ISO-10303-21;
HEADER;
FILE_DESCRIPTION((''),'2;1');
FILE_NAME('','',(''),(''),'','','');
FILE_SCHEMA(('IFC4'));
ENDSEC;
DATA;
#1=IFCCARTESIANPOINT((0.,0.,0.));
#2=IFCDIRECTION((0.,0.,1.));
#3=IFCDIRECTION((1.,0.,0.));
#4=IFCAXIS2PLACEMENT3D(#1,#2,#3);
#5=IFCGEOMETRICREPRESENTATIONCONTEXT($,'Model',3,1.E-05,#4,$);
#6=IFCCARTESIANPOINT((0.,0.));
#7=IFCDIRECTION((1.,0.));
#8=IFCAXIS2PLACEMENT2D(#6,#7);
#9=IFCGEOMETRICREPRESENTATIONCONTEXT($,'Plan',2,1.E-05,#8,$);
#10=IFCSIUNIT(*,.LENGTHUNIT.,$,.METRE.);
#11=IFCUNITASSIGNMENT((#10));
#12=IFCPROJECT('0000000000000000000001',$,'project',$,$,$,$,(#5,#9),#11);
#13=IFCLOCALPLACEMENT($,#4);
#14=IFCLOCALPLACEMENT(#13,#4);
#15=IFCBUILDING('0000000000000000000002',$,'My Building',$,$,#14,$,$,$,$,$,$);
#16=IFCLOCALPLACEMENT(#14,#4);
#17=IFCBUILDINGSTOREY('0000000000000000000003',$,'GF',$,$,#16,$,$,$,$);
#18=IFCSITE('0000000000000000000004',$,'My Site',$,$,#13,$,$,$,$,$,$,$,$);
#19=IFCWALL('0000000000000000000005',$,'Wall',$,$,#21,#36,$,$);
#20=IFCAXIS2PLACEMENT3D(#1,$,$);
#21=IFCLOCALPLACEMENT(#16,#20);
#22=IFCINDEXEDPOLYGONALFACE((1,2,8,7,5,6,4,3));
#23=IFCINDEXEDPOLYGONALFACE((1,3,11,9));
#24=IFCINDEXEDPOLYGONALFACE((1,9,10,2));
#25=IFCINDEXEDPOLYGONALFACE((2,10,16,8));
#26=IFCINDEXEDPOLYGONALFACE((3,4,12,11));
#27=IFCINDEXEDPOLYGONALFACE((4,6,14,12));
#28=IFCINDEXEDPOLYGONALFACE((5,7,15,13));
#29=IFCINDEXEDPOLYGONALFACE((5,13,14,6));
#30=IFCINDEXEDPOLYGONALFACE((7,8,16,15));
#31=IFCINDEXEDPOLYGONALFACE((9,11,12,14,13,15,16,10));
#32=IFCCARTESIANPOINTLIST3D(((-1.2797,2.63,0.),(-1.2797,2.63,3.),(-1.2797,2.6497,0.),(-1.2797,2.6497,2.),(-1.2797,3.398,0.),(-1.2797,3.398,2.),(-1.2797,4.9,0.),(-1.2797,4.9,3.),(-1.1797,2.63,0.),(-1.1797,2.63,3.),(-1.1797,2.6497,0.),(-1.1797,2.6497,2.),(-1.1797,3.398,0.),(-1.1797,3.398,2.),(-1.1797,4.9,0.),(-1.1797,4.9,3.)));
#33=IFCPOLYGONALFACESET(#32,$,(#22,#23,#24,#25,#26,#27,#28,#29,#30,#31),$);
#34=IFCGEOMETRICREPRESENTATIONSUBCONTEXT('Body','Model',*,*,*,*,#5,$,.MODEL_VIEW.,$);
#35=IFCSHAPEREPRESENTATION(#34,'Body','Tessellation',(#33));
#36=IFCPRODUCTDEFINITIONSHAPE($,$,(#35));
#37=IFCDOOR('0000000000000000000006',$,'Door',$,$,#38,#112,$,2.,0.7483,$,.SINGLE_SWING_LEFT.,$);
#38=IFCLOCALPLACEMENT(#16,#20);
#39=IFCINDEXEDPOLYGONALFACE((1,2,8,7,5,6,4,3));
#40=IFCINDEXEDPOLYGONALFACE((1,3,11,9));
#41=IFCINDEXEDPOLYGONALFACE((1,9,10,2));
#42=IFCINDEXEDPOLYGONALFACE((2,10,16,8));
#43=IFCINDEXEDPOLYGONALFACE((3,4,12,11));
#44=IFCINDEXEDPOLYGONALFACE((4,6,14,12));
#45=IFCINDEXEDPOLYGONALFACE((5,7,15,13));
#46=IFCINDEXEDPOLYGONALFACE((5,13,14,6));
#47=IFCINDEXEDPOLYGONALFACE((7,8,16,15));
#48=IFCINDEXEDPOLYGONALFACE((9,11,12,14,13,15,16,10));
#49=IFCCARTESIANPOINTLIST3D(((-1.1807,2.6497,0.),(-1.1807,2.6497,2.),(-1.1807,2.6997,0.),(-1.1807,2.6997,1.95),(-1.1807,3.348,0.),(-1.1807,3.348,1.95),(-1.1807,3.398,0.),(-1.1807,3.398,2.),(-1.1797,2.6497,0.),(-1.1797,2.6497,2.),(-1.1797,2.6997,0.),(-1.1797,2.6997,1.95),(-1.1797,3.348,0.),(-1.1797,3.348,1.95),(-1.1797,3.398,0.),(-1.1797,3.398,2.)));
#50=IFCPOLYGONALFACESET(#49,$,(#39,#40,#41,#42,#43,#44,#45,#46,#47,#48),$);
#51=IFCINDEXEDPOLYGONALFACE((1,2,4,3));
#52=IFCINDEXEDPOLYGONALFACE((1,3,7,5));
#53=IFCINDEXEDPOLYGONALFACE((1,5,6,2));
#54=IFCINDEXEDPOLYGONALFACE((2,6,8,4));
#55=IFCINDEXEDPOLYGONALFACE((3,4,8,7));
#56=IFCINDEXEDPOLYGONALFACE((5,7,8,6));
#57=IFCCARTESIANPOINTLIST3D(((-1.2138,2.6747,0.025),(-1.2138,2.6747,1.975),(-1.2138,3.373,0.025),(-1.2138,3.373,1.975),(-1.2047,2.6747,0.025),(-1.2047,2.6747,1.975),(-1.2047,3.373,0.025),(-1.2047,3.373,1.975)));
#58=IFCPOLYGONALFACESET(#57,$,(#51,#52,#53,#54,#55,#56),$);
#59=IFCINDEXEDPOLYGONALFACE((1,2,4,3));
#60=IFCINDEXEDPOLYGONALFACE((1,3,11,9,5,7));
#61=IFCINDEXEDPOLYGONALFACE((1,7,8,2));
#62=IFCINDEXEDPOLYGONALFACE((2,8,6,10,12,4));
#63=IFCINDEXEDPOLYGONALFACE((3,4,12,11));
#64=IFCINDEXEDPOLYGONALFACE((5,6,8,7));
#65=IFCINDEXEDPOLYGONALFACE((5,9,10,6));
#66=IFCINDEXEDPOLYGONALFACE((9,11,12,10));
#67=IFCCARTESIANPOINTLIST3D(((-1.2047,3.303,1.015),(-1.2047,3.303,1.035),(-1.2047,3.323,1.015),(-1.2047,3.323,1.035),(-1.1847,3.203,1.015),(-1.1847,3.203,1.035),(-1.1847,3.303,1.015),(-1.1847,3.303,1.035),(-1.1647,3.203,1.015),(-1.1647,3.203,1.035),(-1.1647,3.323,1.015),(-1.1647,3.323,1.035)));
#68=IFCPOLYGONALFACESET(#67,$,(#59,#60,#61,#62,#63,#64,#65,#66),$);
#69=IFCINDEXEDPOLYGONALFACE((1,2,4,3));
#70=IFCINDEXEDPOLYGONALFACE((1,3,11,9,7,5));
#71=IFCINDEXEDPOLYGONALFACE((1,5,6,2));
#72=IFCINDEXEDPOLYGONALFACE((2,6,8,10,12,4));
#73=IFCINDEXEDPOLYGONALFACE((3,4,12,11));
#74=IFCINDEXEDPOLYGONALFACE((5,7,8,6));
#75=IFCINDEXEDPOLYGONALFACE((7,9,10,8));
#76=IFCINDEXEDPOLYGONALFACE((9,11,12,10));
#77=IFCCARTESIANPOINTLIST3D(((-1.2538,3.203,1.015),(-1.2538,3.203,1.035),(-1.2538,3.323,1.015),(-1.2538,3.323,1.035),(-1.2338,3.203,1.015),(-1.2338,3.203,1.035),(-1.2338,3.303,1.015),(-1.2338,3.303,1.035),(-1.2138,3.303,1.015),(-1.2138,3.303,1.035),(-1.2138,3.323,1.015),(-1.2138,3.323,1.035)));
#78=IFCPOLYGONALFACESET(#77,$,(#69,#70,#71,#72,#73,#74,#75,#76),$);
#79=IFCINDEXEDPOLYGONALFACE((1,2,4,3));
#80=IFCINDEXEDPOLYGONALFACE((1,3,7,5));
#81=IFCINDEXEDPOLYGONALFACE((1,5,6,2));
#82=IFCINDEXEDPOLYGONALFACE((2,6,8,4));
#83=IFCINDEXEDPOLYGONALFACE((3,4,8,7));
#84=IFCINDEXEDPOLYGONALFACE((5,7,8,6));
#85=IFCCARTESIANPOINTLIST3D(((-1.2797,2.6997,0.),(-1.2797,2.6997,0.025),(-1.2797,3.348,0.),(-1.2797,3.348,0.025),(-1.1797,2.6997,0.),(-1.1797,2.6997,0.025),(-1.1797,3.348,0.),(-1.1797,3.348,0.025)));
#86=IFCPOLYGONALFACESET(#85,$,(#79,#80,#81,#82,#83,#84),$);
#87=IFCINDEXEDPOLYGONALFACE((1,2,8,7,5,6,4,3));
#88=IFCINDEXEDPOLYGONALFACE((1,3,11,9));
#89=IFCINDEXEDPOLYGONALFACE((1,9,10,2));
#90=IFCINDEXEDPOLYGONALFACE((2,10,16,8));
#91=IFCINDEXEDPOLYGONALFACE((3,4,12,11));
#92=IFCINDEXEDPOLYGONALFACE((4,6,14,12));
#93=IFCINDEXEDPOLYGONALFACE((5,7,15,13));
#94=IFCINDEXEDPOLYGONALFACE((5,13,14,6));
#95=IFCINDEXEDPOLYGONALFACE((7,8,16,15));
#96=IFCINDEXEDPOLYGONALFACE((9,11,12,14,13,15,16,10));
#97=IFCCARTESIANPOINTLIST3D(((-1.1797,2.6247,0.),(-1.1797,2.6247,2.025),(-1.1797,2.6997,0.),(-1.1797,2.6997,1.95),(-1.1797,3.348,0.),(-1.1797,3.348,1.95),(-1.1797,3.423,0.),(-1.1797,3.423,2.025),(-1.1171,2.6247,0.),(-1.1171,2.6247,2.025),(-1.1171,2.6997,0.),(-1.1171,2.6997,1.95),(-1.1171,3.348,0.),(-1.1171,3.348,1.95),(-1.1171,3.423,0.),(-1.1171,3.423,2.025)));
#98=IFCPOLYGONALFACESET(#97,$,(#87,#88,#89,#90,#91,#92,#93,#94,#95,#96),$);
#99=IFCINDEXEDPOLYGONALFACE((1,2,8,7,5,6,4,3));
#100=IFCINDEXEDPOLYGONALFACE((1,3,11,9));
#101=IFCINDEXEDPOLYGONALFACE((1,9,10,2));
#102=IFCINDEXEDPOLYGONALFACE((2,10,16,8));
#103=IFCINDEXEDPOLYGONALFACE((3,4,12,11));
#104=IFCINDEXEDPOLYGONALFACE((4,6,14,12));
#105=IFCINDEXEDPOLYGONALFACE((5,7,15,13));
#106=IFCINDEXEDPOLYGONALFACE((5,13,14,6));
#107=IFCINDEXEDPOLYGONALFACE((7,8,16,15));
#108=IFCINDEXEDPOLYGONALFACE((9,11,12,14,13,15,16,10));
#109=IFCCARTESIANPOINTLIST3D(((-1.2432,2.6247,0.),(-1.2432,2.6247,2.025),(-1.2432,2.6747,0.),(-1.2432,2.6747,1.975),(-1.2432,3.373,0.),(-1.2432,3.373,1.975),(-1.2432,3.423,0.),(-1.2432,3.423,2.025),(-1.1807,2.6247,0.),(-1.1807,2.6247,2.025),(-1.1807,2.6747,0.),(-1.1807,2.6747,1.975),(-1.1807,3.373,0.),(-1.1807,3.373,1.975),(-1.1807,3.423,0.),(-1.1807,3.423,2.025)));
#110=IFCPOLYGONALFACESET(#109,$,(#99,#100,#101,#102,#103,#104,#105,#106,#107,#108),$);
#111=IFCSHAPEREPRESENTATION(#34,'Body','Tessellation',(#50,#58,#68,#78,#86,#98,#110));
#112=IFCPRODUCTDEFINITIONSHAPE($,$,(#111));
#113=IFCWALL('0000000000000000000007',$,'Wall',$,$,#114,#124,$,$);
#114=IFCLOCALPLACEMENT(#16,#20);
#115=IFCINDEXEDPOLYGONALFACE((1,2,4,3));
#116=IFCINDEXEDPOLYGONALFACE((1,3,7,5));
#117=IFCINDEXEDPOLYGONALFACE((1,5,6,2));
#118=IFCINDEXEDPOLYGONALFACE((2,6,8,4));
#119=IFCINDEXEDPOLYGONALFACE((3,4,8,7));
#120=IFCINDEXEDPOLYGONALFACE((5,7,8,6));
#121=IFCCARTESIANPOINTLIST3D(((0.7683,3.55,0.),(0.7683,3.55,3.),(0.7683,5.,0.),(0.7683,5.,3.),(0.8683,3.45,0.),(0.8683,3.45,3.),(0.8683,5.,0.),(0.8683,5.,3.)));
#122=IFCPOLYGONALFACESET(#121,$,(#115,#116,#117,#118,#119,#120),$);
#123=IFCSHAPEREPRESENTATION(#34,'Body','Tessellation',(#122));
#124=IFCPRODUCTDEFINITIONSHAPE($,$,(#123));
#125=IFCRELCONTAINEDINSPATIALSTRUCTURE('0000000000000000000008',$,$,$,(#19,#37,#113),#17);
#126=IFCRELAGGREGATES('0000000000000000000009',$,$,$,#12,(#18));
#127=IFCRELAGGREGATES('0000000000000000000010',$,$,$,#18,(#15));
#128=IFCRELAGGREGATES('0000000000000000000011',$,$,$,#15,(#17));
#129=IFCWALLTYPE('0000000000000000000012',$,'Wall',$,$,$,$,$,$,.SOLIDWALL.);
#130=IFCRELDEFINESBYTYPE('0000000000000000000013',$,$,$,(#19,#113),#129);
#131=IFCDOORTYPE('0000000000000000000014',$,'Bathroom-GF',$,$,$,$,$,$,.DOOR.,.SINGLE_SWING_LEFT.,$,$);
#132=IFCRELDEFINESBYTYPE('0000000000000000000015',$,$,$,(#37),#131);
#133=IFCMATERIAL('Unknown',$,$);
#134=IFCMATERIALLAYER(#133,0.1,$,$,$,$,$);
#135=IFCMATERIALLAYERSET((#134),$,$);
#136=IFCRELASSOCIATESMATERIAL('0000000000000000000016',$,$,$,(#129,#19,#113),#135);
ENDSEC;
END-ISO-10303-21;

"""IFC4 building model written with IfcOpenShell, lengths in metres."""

from ifc_helpers import new_model, entity, si_unit, frame, origin_with_axes, origin_2d_with_axis, place, context, subcontext, project, spatial, line, indexed_curve, outline, extrude, shape, source, transform, mapped, material, layer, layer_set, layer_usage, type_object, type_shapes, element, fill, save


model = new_model("IFC4")

# Units and contexts
model_context_1 = context("Model", 3, precision=1e-05, world=origin_with_axes())
plan_context = context("Plan", 2, precision=1e-05, world=origin_2d_with_axis())
body_context_1 = subcontext(model_context_1, "Body", "Model", "MODEL_VIEW")
body_context_2 = subcontext(plan_context, "Body", "Plan", "PLAN_VIEW")
ifc_project = project(units=[si_unit("LENGTHUNIT", "METRE")], contexts=[model_context_1, plan_context])

# Site, building, storey
site_placement = place(None, origin_with_axes())
site = spatial("IfcSite", under=ifc_project, at=site_placement, Name="My Site")
building_placement = place(site_placement, origin_with_axes())
building = spatial("IfcBuilding", under=site, at=building_placement, Name="My Building")
storey_placement = place(building_placement, origin_with_axes())
storey = spatial("IfcBuildingStorey", under=building, at=storey_placement, Name="GF")

# Shared definitions
ifc_material_1 = material(Name="Unknown")

# Shared definitions
ifc_layer_1 = layer(ifc_material_1, 0.1)
ifc_layer_set_1 = layer_set([ifc_layer_1])
wall_type = type_object("IfcWallType", Name="Wall", PredefinedType="SOLIDWALL", material=ifc_layer_set_1)

# Wall, opening, door
ifc_layer_usage_1 = layer_usage(ifc_layer_set_1, "AXIS2", "POSITIVE", 0.0)
wall_1_placement = place(storey_placement, frame((-1.1797, 2.63, 0.0), z_axis=(0.0, 0.0, 1.0), x_axis=(0.0, 1.0, 0.0)))
wall_1 = element("IfcWall", 1, at=wall_1_placement, inside=storey, type_object=wall_type, material=ifc_layer_usage_1, Name="Wall", context=body_context_1, shape_type="SweptSolid", body=[
    extrude(outline(indexed_curve([(0.0, 0.0), (0.0, 0.1), (2.27, 0.1), (2.27, 0.0)], segments=[line(1, 2, 3, 4, 1)])), origin_with_axes(), (0.0, 0.0, 1.0), 3.0),
])
shared_shape_1 = source(origin_with_axes(), body_context_1, "Body", "SweptSolid", [
    extrude(outline(indexed_curve([(0.0, 0.0), (0.7483, 0.0), (0.7483, 2.0), (0.0, 2.0)], segments=[line(1, 2, 3, 4, 1)])), frame((0.0, -0.6, 0.0), z_axis=(0.0, -1.0, 0.0), x_axis=(1.0, 0.0, 0.0)), (0.0, 0.0, -1.0), 1.2),
])
opening_1_placement = place(wall_1_placement, frame((0.0197, 0.0, 0.0), z_axis=(0.0, 0.0, 1.0), x_axis=(1.0, 0.0, 0.0)))
opening_1 = element("IfcOpeningElement", 2, at=opening_1_placement, cuts=wall_1, PredefinedType="OPENING", context=body_context_1, shape_type="MappedRepresentation", body=[
    mapped(shared_shape_1, transform((0.0, 0.0, 0.0), x_axis=(1.0, 0.0, 0.0), y_axis=(0.0, 1.0, 0.0), z_axis=(0.0, 0.0, 1.0), scale=1.0)),
])
door_type_1 = type_object("IfcDoorType", Name="Bathroom-GF", OperationType="SINGLE_SWING_LEFT", PredefinedType="DOOR")
shared_shape_2 = source(origin_with_axes(), body_context_1, "Body", "SweptSolid", [
    extrude(outline(indexed_curve([(0.0, 0.0), (0.0, 2.0), (0.7483, 2.0), (0.7483, 0.0), (0.6983, 0.0), (0.6983, 1.95), (0.05, 1.95), (0.05, 0.0)], segments=[line(1, 2, 3, 4, 5, 6, 7, 8, 1)])), frame((0.0, 0.0, 0.0), z_axis=(0.0, -1.0, 0.0), x_axis=(1.0, 0.0, 0.0)), (0.0, 0.0, -1.0), 0.001),
    extrude(outline(indexed_curve([(0.0, 0.0), (0.6983, 0.0), (0.6983, 0.0092), (0.0, 0.0092)], segments=[line(1, 2, 3, 4, 1)])), frame((0.025, 0.025, 0.025), z_axis=(0.0, 0.0, 1.0), x_axis=(1.0, 0.0, 0.0)), (0.0, 0.0, 1.0), 1.95),
    extrude(outline(indexed_curve([(0.0, 0.0), (0.0, -0.04), (-0.12, -0.04), (-0.12, -0.02), (-0.02, -0.02), (-0.02, 0.0)], segments=[line(1, 2, 3, 4, 5, 6, 1)])), frame((0.6733, 0.025, 1.015), z_axis=(0.0, 0.0, 1.0), x_axis=(1.0, 0.0, 0.0)), (0.0, 0.0, 1.0), 0.02),
    extrude(outline(indexed_curve([(0.0, 0.0), (0.0, 0.04), (-0.12, 0.04), (-0.12, 0.02), (-0.02, 0.02), (-0.02, 0.0)], segments=[line(1, 2, 3, 4, 5, 6, 1)])), frame((0.6733, 0.0342, 1.015), z_axis=(0.0, 0.0, 1.0), x_axis=(1.0, 0.0, 0.0)), (0.0, 0.0, 1.0), 0.02),
    extrude(outline(indexed_curve([(0.0, 0.0), (0.6483, 0.0), (0.6483, 0.1), (0.0, 0.1)], segments=[line(1, 2, 3, 4, 1)])), frame((0.05, 0.0, 0.0), z_axis=(0.0, 0.0, 1.0), x_axis=(1.0, 0.0, 0.0)), (0.0, 0.0, 1.0), 0.025),
    extrude(outline(indexed_curve([(0.0, 0.0), (0.0, 2.025), (0.7983, 2.025), (0.7983, 0.0), (0.7233, 0.0), (0.7233, 1.95), (0.075, 1.95), (0.075, 0.0)], segments=[line(1, 2, 3, 4, 5, 6, 7, 8, 1)])), frame((-0.025, -0.0626, 0.0), z_axis=(0.0, -1.0, 0.0), x_axis=(1.0, 0.0, 0.0)), (0.0, 0.0, -1.0), 0.0626),
    extrude(outline(indexed_curve([(0.0, 0.0), (0.0, 2.025), (0.7983, 2.025), (0.7983, 0.0), (0.7483, 0.0), (0.7483, 1.975), (0.05, 1.975), (0.05, 0.0)], segments=[line(1, 2, 3, 4, 5, 6, 7, 8, 1)])), frame((-0.025, 0.001, 0.0), z_axis=(0.0, -1.0, 0.0), x_axis=(1.0, 0.0, 0.0)), (0.0, 0.0, -1.0), 0.0626),
])
shared_shape_3 = source(origin_with_axes(), body_context_2, "Body", "Curve2D", [
    entity("IfcIndexedPolyCurve", entity("IfcCartesianPointList2D", [[0.0, 0.0], [0.05, 0.0], [0.05, 0.001], [0.0, 0.001]]), [entity("IfcLineIndex", [1, 2, 3, 4, 1])]),
    entity("IfcIndexedPolyCurve", entity("IfcCartesianPointList2D", [[0.7483, 0.0], [0.6983, 0.0], [0.6983, 0.001], [0.7483, 0.001]]), [entity("IfcLineIndex", [1, 2, 3, 4, 1])]),
    entity("IfcTrimmedCurve", entity("IfcEllipse", entity("IfcAxis2Placement2D", entity("IfcCartesianPoint", [0.0342, 0.001]), entity("IfcDirection", [1.0, 0.0])), 0.6891, 0.6983), [entity("IfcCartesianPoint", [0.7233, 0.001])], [entity("IfcCartesianPoint", [0.0342, 0.6993])], True, "CARTESIAN"),
    entity("IfcIndexedPolyCurve", entity("IfcCartesianPointList2D", [[0.025, 0.001], [0.0342, 0.001], [0.0342, 0.6993], [0.025, 0.6993]]), [entity("IfcLineIndex", [1, 2, 3, 4, 1])]),
])
type_shapes(door_type_1, [shared_shape_2, shared_shape_3])
door_1_placement = place(opening_1_placement, frame((0.0, 0.0, 0.0), z_axis=(0.0, 0.0, 1.0), x_axis=(1.0, 0.0, 0.0)))
door_1 = element("IfcDoor", 3, at=door_1_placement, inside=storey, type_object=door_type_1, Name="Door", OperationType="SINGLE_SWING_LEFT", OverallHeight=2.0, OverallWidth=0.7483, shapes=[
    shape(body_context_1, "Body", "MappedRepresentation", [mapped(shared_shape_2, transform((0.0, 0.0, 0.0), x_axis=(1.0, 0.0, 0.0), y_axis=(0.0, 1.0, 0.0), z_axis=(0.0, 0.0, 1.0), scale=1.0))]),
    shape(body_context_2, "Body", "MappedRepresentation", [mapped(shared_shape_3, transform((0.0, 0.0, 0.0), x_axis=(1.0, 0.0, 0.0), y_axis=(0.0, 1.0, 0.0), z_axis=(0.0, 0.0, 1.0), scale=1.0))]),
])
fill(opening_1, door_1)

# Wall
ifc_layer_usage_2 = layer_usage(ifc_layer_set_1, "AXIS2", "POSITIVE", 0.0)
wall_2_placement = place(storey_placement, frame((0.7683, 5.0, 0.0), z_axis=(0.0, 0.0, 1.0), x_axis=(0.0, -1.0, 0.0)))
element("IfcWall", 4, at=wall_2_placement, inside=storey, type_object=wall_type, material=ifc_layer_usage_2, Name="Wall", context=body_context_1, shape_type="SweptSolid", body=[
    extrude(outline(indexed_curve([(0.0, 0.0), (0.0, 0.1), (1.55, 0.1), (1.45, 0.0)], segments=[line(1, 2, 3, 4, 1)])), origin_with_axes(), (0.0, 0.0, 1.0), 3.0),
])

save(model, "model.ifc")
